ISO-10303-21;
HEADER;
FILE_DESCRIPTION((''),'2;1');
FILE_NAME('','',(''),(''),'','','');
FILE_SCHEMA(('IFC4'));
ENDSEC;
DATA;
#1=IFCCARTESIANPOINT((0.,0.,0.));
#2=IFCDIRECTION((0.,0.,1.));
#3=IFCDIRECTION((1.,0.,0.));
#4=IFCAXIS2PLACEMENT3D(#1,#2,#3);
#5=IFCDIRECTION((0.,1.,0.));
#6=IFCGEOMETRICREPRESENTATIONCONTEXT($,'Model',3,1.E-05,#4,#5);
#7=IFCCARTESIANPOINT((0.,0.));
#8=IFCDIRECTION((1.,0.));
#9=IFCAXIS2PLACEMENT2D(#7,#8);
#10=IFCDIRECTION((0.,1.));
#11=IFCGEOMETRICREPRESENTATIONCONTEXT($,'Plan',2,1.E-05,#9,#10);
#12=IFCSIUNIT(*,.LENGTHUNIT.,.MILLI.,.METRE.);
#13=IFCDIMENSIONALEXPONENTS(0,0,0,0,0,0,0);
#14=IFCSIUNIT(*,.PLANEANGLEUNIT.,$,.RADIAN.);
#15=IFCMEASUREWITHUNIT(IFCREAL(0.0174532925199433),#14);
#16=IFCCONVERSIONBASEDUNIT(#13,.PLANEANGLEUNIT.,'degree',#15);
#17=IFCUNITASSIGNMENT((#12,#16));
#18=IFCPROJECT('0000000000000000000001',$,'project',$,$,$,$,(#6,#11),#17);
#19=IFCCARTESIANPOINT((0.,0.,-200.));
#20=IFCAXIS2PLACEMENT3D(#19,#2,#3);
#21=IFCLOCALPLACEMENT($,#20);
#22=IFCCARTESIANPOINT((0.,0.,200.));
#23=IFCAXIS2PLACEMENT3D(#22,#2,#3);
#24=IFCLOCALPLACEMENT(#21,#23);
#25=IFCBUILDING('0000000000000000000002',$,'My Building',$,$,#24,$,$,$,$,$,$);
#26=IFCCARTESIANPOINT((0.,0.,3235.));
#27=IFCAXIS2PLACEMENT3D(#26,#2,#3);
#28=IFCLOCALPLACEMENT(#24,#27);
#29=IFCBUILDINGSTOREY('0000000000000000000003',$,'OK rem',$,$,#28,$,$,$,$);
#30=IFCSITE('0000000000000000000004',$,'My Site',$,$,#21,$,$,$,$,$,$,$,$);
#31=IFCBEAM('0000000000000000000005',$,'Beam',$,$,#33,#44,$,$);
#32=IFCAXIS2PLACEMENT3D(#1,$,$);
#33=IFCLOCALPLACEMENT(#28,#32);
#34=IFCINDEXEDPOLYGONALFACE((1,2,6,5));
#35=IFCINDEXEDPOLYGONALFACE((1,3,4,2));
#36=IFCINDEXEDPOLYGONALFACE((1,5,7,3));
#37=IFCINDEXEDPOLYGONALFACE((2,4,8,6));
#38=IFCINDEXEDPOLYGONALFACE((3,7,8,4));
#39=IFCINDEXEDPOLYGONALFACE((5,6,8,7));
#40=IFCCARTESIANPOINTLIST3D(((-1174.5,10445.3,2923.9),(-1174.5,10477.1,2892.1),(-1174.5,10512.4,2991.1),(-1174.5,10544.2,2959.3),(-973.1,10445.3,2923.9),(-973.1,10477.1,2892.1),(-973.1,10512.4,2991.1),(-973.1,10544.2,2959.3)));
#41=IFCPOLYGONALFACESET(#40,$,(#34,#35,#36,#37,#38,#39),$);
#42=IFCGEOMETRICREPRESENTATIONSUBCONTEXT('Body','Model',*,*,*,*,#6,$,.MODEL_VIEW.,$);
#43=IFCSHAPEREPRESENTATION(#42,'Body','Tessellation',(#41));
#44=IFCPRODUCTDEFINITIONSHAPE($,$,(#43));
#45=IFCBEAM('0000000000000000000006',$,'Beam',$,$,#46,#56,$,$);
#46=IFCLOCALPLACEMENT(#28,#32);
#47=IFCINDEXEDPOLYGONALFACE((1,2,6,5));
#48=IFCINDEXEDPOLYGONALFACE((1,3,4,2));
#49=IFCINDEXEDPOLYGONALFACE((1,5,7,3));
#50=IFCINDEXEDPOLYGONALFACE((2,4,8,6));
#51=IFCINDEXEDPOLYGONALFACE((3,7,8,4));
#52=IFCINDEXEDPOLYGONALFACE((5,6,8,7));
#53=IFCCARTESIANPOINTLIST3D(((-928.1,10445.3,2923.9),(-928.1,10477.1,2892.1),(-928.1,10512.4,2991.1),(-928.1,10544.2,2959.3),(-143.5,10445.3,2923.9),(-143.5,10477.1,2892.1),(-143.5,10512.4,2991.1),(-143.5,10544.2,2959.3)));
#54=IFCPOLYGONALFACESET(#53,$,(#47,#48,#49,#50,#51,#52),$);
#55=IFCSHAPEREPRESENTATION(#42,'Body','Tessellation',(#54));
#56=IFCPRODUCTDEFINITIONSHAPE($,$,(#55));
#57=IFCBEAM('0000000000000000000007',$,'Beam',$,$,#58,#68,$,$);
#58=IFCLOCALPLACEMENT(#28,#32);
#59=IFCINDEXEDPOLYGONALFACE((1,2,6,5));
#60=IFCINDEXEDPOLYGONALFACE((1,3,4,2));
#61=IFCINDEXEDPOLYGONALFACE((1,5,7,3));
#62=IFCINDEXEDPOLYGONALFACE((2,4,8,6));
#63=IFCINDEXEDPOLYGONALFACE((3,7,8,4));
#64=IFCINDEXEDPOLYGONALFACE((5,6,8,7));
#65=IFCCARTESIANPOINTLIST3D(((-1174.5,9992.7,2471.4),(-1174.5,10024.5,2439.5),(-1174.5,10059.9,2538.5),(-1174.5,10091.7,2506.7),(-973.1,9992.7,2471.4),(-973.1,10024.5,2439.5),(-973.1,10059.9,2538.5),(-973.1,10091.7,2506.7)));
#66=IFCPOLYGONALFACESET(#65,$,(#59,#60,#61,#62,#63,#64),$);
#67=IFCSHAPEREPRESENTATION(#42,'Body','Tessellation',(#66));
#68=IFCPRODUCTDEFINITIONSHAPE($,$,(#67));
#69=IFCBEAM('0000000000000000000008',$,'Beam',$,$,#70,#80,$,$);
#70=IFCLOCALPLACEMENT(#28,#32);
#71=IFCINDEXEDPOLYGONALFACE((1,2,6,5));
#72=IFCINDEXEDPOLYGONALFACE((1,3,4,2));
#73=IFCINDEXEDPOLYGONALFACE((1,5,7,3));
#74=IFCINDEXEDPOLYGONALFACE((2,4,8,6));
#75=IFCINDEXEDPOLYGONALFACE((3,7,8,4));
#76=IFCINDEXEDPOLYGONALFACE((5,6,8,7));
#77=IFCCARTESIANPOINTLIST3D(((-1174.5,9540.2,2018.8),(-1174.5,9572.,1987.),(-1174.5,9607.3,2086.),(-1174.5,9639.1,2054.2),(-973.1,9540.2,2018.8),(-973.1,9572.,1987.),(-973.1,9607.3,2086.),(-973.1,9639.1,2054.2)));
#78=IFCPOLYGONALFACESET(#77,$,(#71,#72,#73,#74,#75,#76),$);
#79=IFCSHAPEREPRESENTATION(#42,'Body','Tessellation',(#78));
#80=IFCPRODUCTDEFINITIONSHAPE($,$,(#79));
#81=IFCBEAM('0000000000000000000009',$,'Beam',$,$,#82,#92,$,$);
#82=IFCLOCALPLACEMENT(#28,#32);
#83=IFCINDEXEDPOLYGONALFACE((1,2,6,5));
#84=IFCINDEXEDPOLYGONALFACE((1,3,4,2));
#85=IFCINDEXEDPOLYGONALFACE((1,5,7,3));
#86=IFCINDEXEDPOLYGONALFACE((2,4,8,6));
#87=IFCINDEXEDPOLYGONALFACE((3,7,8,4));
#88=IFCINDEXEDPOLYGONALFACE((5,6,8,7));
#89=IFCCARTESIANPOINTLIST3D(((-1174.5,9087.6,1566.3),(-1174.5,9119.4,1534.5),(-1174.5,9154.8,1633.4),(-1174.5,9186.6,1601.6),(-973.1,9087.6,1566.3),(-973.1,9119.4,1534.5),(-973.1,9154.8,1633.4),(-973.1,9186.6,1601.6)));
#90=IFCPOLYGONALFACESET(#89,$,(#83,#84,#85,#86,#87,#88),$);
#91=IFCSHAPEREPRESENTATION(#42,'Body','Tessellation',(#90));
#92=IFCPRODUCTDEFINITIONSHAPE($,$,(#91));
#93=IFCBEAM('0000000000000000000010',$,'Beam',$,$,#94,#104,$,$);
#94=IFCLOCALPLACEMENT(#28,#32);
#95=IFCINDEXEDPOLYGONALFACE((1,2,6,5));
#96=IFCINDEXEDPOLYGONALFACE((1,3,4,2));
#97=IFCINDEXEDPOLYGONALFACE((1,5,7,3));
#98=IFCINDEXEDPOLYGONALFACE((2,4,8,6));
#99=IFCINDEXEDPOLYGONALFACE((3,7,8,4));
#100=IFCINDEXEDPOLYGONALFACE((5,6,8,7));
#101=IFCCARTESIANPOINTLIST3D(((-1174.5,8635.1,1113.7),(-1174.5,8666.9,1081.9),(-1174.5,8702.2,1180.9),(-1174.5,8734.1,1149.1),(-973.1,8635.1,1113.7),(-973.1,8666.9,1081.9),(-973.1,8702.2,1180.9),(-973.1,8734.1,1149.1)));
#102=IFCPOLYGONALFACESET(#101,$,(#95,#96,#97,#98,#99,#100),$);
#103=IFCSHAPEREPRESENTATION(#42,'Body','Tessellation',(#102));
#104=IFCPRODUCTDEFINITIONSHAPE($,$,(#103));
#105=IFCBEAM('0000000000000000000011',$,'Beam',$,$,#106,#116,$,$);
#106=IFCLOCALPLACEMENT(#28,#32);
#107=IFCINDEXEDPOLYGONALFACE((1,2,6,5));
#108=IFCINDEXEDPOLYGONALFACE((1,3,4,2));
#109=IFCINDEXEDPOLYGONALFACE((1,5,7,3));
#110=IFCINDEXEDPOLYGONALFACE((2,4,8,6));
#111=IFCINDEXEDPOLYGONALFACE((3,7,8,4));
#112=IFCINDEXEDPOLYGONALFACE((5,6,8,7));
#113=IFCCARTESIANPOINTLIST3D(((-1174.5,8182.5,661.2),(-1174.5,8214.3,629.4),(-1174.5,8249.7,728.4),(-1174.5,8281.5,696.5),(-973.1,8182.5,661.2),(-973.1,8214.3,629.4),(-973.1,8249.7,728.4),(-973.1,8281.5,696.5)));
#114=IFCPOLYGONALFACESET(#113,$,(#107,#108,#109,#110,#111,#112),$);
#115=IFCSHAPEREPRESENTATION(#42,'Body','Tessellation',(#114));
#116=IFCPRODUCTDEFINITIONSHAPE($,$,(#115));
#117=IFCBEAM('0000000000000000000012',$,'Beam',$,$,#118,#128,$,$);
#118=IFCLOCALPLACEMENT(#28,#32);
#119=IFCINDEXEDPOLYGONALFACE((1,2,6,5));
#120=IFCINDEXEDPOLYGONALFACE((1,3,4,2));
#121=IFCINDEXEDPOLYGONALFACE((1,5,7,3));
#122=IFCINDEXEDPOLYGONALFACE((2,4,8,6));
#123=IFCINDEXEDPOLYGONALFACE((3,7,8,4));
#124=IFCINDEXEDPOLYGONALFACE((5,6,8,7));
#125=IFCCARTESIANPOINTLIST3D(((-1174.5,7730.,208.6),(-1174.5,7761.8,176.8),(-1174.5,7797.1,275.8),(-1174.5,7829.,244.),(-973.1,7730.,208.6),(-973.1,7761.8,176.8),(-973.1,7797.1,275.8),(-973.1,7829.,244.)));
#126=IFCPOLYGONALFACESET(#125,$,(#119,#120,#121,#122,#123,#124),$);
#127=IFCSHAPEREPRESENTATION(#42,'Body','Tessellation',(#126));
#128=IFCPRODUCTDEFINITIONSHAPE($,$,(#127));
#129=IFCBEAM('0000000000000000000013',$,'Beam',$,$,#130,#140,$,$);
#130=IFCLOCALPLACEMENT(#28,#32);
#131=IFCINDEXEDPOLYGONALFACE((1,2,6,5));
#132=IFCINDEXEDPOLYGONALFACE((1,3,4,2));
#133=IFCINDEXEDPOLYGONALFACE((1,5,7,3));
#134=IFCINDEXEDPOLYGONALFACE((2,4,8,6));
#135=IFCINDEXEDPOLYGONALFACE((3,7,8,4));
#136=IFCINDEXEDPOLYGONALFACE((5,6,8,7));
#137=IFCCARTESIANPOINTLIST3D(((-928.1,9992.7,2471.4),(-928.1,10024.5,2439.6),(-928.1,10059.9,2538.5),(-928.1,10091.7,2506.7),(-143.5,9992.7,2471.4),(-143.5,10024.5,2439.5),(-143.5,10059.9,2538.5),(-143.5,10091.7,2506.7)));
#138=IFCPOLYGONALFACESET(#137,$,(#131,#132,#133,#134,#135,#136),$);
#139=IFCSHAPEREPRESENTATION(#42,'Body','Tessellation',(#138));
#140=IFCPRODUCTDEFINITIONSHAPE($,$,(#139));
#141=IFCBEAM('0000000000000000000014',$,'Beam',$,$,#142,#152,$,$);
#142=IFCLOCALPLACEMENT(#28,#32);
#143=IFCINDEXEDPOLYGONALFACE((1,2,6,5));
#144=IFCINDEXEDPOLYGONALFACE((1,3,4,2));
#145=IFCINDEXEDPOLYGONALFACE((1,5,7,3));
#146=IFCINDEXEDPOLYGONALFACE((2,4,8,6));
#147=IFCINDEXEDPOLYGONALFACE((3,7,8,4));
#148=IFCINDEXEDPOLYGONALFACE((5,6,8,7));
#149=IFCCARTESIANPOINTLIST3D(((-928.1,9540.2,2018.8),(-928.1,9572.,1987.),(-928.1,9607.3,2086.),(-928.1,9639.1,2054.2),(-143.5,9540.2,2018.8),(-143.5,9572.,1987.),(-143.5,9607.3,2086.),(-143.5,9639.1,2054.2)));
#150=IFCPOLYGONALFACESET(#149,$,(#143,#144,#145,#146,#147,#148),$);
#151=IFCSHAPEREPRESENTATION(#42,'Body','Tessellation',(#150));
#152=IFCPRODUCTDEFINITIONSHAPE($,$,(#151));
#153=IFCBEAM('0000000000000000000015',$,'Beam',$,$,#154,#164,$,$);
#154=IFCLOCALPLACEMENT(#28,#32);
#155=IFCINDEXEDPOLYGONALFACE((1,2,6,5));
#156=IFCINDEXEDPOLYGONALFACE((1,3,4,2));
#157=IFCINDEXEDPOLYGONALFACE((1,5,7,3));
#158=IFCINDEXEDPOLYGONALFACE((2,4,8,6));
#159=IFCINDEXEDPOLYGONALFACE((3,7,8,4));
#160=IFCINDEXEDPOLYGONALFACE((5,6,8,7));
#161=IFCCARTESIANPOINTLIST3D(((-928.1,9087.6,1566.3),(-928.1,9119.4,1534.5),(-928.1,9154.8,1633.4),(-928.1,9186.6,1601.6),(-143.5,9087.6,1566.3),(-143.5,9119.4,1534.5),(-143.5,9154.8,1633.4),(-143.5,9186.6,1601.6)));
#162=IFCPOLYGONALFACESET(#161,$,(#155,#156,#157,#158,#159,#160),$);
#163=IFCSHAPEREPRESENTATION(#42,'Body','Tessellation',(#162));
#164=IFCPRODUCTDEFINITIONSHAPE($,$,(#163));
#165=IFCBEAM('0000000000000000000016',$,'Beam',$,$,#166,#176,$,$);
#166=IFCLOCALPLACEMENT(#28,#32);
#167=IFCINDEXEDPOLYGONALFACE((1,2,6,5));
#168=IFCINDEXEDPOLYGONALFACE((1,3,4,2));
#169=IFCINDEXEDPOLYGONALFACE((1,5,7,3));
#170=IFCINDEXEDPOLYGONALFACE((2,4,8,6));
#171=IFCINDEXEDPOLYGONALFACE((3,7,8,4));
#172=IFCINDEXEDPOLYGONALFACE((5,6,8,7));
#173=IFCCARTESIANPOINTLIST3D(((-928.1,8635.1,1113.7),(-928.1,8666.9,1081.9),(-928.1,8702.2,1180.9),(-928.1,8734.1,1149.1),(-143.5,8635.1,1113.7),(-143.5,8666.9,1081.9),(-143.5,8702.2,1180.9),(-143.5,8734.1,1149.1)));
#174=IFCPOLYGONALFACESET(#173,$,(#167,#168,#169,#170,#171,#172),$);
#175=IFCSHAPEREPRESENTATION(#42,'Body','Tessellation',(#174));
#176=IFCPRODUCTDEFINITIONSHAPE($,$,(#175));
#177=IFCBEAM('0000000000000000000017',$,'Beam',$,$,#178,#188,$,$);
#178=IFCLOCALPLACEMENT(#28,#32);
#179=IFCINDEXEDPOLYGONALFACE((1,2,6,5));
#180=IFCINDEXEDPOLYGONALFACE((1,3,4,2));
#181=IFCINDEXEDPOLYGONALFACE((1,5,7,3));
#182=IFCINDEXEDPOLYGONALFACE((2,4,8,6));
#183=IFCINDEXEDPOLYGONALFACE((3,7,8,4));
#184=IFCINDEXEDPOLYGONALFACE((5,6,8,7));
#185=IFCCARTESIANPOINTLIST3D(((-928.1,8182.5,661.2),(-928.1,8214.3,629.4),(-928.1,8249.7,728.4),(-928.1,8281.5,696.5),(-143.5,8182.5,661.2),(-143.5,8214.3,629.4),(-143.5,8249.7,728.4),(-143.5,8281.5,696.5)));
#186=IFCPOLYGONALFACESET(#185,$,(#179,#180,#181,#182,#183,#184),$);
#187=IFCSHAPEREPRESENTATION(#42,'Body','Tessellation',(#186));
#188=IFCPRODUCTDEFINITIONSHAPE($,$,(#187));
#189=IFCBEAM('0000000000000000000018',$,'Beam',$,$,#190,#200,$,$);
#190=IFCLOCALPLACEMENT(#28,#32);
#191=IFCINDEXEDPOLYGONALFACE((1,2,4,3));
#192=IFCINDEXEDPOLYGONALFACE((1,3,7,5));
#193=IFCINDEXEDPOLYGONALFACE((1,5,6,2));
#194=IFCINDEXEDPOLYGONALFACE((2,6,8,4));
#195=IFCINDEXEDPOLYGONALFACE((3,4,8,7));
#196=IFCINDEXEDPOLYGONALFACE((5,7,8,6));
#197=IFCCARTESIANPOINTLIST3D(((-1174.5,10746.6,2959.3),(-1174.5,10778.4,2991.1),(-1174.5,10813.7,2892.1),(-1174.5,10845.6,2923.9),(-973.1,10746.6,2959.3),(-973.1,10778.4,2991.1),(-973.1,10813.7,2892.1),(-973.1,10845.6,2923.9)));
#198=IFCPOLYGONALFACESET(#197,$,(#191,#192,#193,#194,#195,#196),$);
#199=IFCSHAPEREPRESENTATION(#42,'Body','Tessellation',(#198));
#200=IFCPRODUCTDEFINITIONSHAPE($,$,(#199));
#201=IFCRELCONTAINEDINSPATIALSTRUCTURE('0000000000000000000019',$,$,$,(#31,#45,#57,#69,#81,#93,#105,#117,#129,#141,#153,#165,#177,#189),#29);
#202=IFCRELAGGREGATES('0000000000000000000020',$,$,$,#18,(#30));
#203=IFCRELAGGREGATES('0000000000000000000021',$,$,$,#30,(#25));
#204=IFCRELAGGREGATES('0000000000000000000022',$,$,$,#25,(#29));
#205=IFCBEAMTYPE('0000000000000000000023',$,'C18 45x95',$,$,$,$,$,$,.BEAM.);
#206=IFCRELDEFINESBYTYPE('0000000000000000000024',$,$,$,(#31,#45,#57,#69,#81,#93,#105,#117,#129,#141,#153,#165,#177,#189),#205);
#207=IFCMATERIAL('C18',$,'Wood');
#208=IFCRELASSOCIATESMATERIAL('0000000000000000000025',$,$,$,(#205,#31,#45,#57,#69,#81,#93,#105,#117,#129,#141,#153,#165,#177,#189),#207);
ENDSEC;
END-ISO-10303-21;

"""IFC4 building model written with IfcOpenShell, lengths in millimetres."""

from ifc_helpers import new_model, entity, si_unit, converted_unit, direction, frame, origin_with_axes, origin_2d_with_axis, place, context, subcontext, project, spatial, rectangle, extrude, material, material_profile, profile_set, profile_usage, type_object, element, save


model = new_model("IFC4")

# Units and contexts
model_context = context("Model", 3, precision=1e-05, world=origin_with_axes(), true_north=direction((0.0, 1.0, 0.0)))
plan_context = context("Plan", 2, precision=1e-05, world=origin_2d_with_axis(), true_north=direction((0.0, 1.0)))
body_context = subcontext(model_context, "Body", "Model", "MODEL_VIEW")
ifc_project = project(units=[si_unit("LENGTHUNIT", "METRE", prefix="MILLI"), converted_unit("PLANEANGLEUNIT", "degree", entity("IfcReal", 0.0174532925199433), si_unit("PLANEANGLEUNIT", "RADIAN"), dimensions=[0, 0, 0, 0, 0, 0, 0])], contexts=[model_context, plan_context])

# Site, building, storey
site_placement = place(None, frame((0.0, 0.0, -200.0), z_axis=(0.0, 0.0, 1.0), x_axis=(1.0, 0.0, 0.0)))
site = spatial("IfcSite", under=ifc_project, at=site_placement, Name="My Site")
building_placement = place(site_placement, frame((0.0, 0.0, 200.0), z_axis=(0.0, 0.0, 1.0), x_axis=(1.0, 0.0, 0.0)))
building = spatial("IfcBuilding", under=site, at=building_placement, Name="My Building")
storey_placement = place(building_placement, frame((0.0, 0.0, 3235.0), z_axis=(0.0, 0.0, 1.0), x_axis=(1.0, 0.0, 0.0)))
storey = spatial("IfcBuildingStorey", under=building, at=storey_placement, Name="OK rem")

# Beams
ifc_material_1 = material(Name="C18", Category="Wood")
ifc_material_profile_1 = material_profile(ifc_material_1, rectangle(XDim=45.0, YDim=95.0))
ifc_profile_set_1 = profile_set([ifc_material_profile_1], Name="woodStructural")
ifc_profile_usage_1 = profile_usage(ifc_profile_set_1, cardinal=5)
beam_type_1 = type_object("IfcBeamType", Name="C18 45x95", PredefinedType="BEAM", material=ifc_profile_set_1)
beam_1_placement = place(storey_placement, frame((-1174.5, 10494.7, 2941.6), z_axis=(1.0, 0.0, 0.0), x_axis=(0.0, 0.707107, -0.707107)))
element("IfcBeam", 1, at=beam_1_placement, inside=storey, type_object=beam_type_1, material=ifc_profile_usage_1, Name="Beam", context=body_context, shape_type="SweptSolid", body=[
    extrude(rectangle(XDim=45.0, YDim=95.0), origin_with_axes(), (0.0, 0.0, 1.0), 201.3),
])
ifc_profile_usage_2 = profile_usage(ifc_profile_set_1, cardinal=5)
beam_2_placement = place(storey_placement, frame((-928.1, 10494.7, 2941.6), z_axis=(1.0, 0.0, 0.0), x_axis=(0.0, 0.707107, -0.707107)))
element("IfcBeam", 2, at=beam_2_placement, inside=storey, type_object=beam_type_1, material=ifc_profile_usage_2, Name="Beam", context=body_context, shape_type="SweptSolid", body=[
    extrude(rectangle(XDim=45.0, YDim=95.0), origin_with_axes(), (0.0, 0.0, 1.0), 784.6),
])
ifc_profile_usage_3 = profile_usage(ifc_profile_set_1, cardinal=5)
beam_3_placement = place(storey_placement, frame((-1174.5, 10042.2, 2489.0), z_axis=(1.0, 0.0, 0.0), x_axis=(0.0, 0.707107, -0.707107)))
element("IfcBeam", 3, at=beam_3_placement, inside=storey, type_object=beam_type_1, material=ifc_profile_usage_3, Name="Beam", context=body_context, shape_type="SweptSolid", body=[
    extrude(rectangle(XDim=45.0, YDim=95.0), origin_with_axes(), (0.0, 0.0, 1.0), 201.3),
])
ifc_profile_usage_4 = profile_usage(ifc_profile_set_1, cardinal=5)
beam_4_placement = place(storey_placement, frame((-1174.5, 9589.7, 2036.5), z_axis=(1.0, 0.0, 0.0), x_axis=(0.0, 0.707107, -0.707107)))
element("IfcBeam", 4, at=beam_4_placement, inside=storey, type_object=beam_type_1, material=ifc_profile_usage_4, Name="Beam", context=body_context, shape_type="SweptSolid", body=[
    extrude(rectangle(XDim=45.0, YDim=95.0), origin_with_axes(), (0.0, 0.0, 1.0), 201.3),
])
ifc_profile_usage_5 = profile_usage(ifc_profile_set_1, cardinal=5)
beam_5_placement = place(storey_placement, frame((-1174.5, 9137.1, 1584.0), z_axis=(1.0, 0.0, 0.0), x_axis=(0.0, 0.707107, -0.707107)))
element("IfcBeam", 5, at=beam_5_placement, inside=storey, type_object=beam_type_1, material=ifc_profile_usage_5, Name="Beam", context=body_context, shape_type="SweptSolid", body=[
    extrude(rectangle(XDim=45.0, YDim=95.0), origin_with_axes(), (0.0, 0.0, 1.0), 201.3),
])
ifc_profile_usage_6 = profile_usage(ifc_profile_set_1, cardinal=5)
beam_6_placement = place(storey_placement, frame((-1174.5, 8684.6, 1131.4), z_axis=(1.0, 0.0, 0.0), x_axis=(0.0, 0.707107, -0.707107)))
element("IfcBeam", 6, at=beam_6_placement, inside=storey, type_object=beam_type_1, material=ifc_profile_usage_6, Name="Beam", context=body_context, shape_type="SweptSolid", body=[
    extrude(rectangle(XDim=45.0, YDim=95.0), origin_with_axes(), (0.0, 0.0, 1.0), 201.3),
])
ifc_profile_usage_7 = profile_usage(ifc_profile_set_1, cardinal=5)
beam_7_placement = place(storey_placement, frame((-1174.5, 8232.0, 678.9), z_axis=(1.0, 0.0, 0.0), x_axis=(0.0, 0.707107, -0.707107)))
element("IfcBeam", 7, at=beam_7_placement, inside=storey, type_object=beam_type_1, material=ifc_profile_usage_7, Name="Beam", context=body_context, shape_type="SweptSolid", body=[
    extrude(rectangle(XDim=45.0, YDim=95.0), origin_with_axes(), (0.0, 0.0, 1.0), 201.3),
])
ifc_profile_usage_8 = profile_usage(ifc_profile_set_1, cardinal=5)
beam_8_placement = place(storey_placement, frame((-1174.5, 7779.5, 226.3), z_axis=(1.0, 0.0, 0.0), x_axis=(0.0, 0.707107, -0.707107)))
element("IfcBeam", 8, at=beam_8_placement, inside=storey, type_object=beam_type_1, material=ifc_profile_usage_8, Name="Beam", context=body_context, shape_type="SweptSolid", body=[
    extrude(rectangle(XDim=45.0, YDim=95.0), origin_with_axes(), (0.0, 0.0, 1.0), 201.3),
])
ifc_profile_usage_9 = profile_usage(ifc_profile_set_1, cardinal=5)
beam_9_placement = place(storey_placement, frame((-928.1, 10042.2, 2489.0), z_axis=(1.0, 0.0, 0.0), x_axis=(0.0, 0.707107, -0.707107)))
element("IfcBeam", 9, at=beam_9_placement, inside=storey, type_object=beam_type_1, material=ifc_profile_usage_9, Name="Beam", context=body_context, shape_type="SweptSolid", body=[
    extrude(rectangle(XDim=45.0, YDim=95.0), origin_with_axes(), (0.0, 0.0, 1.0), 784.6),
])
ifc_profile_usage_10 = profile_usage(ifc_profile_set_1, cardinal=5)
beam_10_placement = place(storey_placement, frame((-928.1, 9589.7, 2036.5), z_axis=(1.0, 0.0, 0.0), x_axis=(0.0, 0.707107, -0.707107)))
element("IfcBeam", 10, at=beam_10_placement, inside=storey, type_object=beam_type_1, material=ifc_profile_usage_10, Name="Beam", context=body_context, shape_type="SweptSolid", body=[
    extrude(rectangle(XDim=45.0, YDim=95.0), origin_with_axes(), (0.0, 0.0, 1.0), 784.6),
])
ifc_profile_usage_11 = profile_usage(ifc_profile_set_1, cardinal=5)
beam_11_placement = place(storey_placement, frame((-928.1, 9137.1, 1584.0), z_axis=(1.0, 0.0, 0.0), x_axis=(0.0, 0.707107, -0.707107)))
element("IfcBeam", 11, at=beam_11_placement, inside=storey, type_object=beam_type_1, material=ifc_profile_usage_11, Name="Beam", context=body_context, shape_type="SweptSolid", body=[
    extrude(rectangle(XDim=45.0, YDim=95.0), origin_with_axes(), (0.0, 0.0, 1.0), 784.6),
])
ifc_profile_usage_12 = profile_usage(ifc_profile_set_1, cardinal=5)
beam_12_placement = place(storey_placement, frame((-928.1, 8684.6, 1131.4), z_axis=(1.0, 0.0, 0.0), x_axis=(0.0, 0.707107, -0.707107)))
element("IfcBeam", 12, at=beam_12_placement, inside=storey, type_object=beam_type_1, material=ifc_profile_usage_12, Name="Beam", context=body_context, shape_type="SweptSolid", body=[
    extrude(rectangle(XDim=45.0, YDim=95.0), origin_with_axes(), (0.0, 0.0, 1.0), 784.6),
])
ifc_profile_usage_13 = profile_usage(ifc_profile_set_1, cardinal=5)
beam_13_placement = place(storey_placement, frame((-928.1, 8232.0, 678.9), z_axis=(1.0, 0.0, 0.0), x_axis=(0.0, 0.707107, -0.707107)))
element("IfcBeam", 13, at=beam_13_placement, inside=storey, type_object=beam_type_1, material=ifc_profile_usage_13, Name="Beam", context=body_context, shape_type="SweptSolid", body=[
    extrude(rectangle(XDim=45.0, YDim=95.0), origin_with_axes(), (0.0, 0.0, 1.0), 784.6),
])
ifc_profile_usage_14 = profile_usage(ifc_profile_set_1, cardinal=5)
beam_14_placement = place(storey_placement, frame((-1174.5, 10796.1, 2941.6), z_axis=(1.0, 0.0, 0.0), x_axis=(0.0, 0.707107, 0.707107)))
element("IfcBeam", 14, at=beam_14_placement, inside=storey, type_object=beam_type_1, material=ifc_profile_usage_14, Name="Beam", context=body_context, shape_type="SweptSolid", body=[
    extrude(rectangle(XDim=45.0, YDim=95.0), origin_with_axes(), (0.0, 0.0, 1.0), 201.3),
])

save(model, "model.ifc")
